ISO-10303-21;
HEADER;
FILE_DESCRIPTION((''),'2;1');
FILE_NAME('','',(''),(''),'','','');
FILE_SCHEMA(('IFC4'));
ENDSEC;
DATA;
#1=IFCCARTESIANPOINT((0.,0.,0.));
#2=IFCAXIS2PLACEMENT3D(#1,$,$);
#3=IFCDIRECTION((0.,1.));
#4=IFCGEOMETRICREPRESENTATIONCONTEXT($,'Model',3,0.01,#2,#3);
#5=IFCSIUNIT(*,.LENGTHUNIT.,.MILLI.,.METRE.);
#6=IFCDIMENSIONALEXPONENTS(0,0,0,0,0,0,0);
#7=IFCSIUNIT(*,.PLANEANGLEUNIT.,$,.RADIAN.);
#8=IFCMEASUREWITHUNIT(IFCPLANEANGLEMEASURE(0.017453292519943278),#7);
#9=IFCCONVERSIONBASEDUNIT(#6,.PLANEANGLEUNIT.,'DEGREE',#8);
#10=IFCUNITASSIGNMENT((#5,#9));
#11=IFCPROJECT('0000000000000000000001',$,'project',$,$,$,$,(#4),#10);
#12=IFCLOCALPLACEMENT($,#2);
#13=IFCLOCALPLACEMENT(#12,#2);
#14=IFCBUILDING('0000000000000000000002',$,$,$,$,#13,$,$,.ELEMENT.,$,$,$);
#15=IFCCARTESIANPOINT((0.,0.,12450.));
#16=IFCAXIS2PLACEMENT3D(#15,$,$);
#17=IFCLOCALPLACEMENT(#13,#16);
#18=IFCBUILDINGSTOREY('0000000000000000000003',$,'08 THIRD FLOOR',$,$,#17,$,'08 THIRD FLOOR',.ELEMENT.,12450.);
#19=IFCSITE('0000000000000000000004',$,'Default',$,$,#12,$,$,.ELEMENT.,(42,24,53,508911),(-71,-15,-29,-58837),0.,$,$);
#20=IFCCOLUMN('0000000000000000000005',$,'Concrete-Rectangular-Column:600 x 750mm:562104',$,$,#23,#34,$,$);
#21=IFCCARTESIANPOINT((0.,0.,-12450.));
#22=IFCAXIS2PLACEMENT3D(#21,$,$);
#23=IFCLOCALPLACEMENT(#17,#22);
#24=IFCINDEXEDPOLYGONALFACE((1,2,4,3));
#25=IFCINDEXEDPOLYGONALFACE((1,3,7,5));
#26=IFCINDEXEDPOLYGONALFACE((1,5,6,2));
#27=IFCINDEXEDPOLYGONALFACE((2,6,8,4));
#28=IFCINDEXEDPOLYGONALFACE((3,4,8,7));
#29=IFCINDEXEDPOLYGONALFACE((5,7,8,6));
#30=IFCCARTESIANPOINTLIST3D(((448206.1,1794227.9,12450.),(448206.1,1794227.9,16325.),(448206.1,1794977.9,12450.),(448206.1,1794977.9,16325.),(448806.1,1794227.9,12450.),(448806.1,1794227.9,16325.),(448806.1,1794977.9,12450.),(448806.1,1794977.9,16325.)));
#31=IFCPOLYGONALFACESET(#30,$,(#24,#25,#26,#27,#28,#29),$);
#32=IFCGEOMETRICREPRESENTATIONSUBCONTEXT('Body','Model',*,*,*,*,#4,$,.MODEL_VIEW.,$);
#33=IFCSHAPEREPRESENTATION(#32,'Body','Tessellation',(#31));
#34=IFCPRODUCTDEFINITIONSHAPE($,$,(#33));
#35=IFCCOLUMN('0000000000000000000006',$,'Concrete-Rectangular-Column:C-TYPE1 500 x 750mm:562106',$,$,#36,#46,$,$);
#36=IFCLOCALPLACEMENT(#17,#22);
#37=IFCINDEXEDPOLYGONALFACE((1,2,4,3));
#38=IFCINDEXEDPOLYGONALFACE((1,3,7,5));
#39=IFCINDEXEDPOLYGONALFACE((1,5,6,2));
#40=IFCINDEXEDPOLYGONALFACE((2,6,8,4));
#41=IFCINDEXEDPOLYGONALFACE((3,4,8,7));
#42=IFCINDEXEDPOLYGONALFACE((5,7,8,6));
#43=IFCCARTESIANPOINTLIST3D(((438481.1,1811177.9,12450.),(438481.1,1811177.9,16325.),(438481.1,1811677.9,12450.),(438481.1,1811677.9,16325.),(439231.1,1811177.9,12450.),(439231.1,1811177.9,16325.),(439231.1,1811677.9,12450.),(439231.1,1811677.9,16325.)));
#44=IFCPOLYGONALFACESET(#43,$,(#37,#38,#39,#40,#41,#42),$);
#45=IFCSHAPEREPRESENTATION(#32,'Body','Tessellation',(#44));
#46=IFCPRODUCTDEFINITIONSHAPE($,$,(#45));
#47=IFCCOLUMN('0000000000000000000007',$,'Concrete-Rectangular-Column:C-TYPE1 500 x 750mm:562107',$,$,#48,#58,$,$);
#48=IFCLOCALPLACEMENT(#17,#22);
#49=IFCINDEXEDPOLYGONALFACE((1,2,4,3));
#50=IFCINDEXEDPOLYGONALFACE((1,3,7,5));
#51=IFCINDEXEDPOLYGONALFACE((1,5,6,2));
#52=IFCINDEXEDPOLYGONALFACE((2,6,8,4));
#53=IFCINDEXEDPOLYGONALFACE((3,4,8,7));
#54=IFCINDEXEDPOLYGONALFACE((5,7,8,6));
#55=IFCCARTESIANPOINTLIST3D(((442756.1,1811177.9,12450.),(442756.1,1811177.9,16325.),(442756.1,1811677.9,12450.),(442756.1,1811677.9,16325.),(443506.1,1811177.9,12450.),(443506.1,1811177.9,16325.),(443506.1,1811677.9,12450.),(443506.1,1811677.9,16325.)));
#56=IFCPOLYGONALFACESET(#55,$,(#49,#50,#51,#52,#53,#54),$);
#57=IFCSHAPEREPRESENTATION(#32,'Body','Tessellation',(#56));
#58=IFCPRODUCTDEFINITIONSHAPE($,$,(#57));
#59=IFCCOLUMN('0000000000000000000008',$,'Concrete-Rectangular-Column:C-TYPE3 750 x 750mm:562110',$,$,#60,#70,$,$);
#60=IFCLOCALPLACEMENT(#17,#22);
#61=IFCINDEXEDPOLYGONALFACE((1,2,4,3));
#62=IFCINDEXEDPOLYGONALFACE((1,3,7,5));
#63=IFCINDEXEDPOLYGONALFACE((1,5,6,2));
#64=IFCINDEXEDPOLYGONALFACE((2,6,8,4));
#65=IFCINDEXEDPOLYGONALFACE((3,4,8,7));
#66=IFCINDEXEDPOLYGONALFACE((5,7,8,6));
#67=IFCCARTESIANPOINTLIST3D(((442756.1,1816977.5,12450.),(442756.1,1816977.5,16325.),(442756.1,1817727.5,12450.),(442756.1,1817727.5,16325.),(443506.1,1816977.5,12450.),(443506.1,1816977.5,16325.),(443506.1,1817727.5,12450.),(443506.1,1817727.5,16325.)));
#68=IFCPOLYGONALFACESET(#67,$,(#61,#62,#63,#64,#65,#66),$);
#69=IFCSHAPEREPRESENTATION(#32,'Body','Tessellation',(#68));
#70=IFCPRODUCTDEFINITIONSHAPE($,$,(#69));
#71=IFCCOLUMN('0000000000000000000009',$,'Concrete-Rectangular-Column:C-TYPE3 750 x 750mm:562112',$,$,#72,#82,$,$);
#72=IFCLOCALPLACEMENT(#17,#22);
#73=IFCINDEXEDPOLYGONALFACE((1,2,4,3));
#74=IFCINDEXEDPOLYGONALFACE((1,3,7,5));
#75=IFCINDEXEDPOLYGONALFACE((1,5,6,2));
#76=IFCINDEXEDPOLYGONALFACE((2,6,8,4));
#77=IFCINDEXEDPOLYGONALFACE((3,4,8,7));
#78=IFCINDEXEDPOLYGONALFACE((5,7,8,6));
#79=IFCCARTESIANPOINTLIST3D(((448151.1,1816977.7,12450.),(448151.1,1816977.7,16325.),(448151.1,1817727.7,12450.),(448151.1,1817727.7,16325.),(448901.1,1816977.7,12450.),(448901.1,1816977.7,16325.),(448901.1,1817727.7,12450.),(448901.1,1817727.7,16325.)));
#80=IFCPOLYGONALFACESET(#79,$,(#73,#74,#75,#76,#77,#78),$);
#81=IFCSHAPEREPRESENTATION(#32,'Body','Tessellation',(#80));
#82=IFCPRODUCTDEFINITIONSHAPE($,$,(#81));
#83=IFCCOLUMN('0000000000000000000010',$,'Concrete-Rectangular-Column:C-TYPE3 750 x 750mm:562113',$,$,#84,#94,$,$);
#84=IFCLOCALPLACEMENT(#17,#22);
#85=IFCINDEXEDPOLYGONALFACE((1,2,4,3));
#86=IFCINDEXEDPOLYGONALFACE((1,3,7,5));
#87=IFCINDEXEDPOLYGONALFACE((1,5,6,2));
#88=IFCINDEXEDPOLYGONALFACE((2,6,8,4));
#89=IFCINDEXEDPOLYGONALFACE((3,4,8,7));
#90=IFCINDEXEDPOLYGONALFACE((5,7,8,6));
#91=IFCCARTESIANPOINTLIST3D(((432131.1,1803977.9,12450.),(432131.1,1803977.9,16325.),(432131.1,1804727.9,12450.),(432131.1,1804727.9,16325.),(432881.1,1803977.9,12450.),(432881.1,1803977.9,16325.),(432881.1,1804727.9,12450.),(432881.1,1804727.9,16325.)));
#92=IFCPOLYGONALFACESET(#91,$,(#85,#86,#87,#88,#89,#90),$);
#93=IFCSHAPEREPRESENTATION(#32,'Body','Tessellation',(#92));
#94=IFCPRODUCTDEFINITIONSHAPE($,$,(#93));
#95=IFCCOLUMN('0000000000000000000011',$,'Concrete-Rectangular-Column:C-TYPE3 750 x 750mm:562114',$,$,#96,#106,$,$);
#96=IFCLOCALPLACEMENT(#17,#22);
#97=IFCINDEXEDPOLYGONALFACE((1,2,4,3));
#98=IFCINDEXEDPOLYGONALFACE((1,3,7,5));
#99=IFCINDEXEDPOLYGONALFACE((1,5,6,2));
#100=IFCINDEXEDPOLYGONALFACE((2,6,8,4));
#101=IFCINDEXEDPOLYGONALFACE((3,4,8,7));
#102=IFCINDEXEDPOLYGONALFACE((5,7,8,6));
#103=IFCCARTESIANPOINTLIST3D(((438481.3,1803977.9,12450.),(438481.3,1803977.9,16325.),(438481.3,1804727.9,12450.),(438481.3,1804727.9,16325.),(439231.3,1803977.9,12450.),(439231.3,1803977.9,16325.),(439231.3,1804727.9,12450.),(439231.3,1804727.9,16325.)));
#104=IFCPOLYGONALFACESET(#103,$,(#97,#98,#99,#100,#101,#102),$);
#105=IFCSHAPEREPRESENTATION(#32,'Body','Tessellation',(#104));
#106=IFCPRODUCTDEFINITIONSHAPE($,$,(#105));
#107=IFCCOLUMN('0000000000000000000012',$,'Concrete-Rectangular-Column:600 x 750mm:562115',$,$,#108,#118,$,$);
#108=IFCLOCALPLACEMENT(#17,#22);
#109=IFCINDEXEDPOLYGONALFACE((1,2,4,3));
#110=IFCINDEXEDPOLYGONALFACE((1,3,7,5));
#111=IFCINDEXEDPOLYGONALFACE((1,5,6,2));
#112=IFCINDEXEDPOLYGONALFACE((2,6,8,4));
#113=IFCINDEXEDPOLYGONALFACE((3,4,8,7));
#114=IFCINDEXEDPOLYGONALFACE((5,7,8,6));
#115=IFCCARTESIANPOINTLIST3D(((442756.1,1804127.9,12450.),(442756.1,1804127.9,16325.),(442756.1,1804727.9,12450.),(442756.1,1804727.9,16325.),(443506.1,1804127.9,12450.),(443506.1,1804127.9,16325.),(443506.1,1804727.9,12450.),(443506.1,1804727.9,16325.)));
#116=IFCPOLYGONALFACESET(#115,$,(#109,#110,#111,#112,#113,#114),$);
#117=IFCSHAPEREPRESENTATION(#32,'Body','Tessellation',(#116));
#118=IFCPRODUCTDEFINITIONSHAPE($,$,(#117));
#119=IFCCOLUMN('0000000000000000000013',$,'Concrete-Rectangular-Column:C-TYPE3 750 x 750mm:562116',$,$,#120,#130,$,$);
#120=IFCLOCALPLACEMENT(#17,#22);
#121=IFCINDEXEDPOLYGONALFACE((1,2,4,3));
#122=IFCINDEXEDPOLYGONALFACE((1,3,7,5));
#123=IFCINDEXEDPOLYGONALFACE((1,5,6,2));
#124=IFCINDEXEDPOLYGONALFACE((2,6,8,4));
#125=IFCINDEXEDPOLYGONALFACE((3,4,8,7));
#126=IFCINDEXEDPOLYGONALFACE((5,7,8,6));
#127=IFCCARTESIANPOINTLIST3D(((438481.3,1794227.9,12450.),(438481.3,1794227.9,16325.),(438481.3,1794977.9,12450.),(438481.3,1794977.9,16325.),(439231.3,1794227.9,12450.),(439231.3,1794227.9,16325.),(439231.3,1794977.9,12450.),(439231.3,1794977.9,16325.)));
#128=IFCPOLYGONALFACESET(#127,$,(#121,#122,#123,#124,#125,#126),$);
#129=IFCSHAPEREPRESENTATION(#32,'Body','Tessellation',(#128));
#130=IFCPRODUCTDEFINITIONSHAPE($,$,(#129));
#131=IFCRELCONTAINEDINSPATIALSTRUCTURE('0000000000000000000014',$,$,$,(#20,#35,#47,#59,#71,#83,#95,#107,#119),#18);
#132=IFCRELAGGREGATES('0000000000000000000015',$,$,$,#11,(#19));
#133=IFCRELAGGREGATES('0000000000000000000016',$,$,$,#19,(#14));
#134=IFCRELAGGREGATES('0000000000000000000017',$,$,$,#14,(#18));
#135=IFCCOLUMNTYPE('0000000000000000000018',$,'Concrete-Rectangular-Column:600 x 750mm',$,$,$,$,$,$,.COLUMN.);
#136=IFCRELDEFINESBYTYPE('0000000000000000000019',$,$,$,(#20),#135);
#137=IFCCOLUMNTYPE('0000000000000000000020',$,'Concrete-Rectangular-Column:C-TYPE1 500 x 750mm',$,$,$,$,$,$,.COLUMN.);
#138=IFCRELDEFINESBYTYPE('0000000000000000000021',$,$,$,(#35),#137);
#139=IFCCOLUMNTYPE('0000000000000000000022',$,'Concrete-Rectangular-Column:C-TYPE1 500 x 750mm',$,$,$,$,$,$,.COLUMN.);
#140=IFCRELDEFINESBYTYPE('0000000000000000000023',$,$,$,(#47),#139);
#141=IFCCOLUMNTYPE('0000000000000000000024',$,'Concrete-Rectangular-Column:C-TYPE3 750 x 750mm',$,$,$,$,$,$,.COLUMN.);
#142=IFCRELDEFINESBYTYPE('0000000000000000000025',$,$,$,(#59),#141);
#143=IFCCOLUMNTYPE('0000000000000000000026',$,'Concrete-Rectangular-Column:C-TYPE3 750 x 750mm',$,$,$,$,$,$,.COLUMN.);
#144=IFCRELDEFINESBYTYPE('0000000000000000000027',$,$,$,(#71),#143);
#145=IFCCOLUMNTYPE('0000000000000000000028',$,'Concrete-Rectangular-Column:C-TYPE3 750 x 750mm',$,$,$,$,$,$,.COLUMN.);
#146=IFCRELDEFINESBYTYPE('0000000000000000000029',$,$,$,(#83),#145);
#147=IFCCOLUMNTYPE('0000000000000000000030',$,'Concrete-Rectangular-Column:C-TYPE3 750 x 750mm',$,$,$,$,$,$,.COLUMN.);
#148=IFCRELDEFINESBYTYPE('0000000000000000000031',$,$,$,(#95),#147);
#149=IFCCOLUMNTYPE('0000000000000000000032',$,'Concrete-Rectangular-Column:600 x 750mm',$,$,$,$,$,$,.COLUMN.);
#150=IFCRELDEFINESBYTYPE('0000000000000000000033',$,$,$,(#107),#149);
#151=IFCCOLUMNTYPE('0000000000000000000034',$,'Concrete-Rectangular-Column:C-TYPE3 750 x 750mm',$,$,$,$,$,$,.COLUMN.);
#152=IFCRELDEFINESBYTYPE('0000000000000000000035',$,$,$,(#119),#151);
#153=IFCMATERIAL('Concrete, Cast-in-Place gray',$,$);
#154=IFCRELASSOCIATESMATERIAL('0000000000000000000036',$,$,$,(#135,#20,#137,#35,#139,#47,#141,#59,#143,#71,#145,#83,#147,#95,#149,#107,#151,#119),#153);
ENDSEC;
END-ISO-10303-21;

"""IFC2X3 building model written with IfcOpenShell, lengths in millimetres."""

from ifc_helpers import new_model, entity, si_unit, converted_unit, direction, frame, frame_2d, origin, place, context, subcontext, project, spatial, rectangle, extrude, source, transform, mapped, material, type_object, type_shapes, element, save


model = new_model("IFC2X3")

# Units and contexts
model_context = context("Model", 3, precision=0.01, world=origin(), true_north=direction((0.0, 1.0)))
body_context = subcontext(model_context, "Body", "Model", "MODEL_VIEW")
ifc_project = project(units=[si_unit("LENGTHUNIT", "METRE", prefix="MILLI"), converted_unit("PLANEANGLEUNIT", "DEGREE", entity("IfcPlaneAngleMeasure", 0.017453292519943278), si_unit("PLANEANGLEUNIT", "RADIAN"), dimensions=[0, 0, 0, 0, 0, 0, 0])], contexts=[model_context])

# Site, building, storey
site_placement = place(None, origin())
site = spatial("IfcSite", under=ifc_project, at=site_placement, Name="Default", CompositionType="ELEMENT", RefLatitude=(42, 24, 53, 508911), RefLongitude=(-71, -15, -29, -58837), RefElevation=0.0)
building_placement = place(site_placement, origin())
building = spatial("IfcBuilding", under=site, at=building_placement, CompositionType="ELEMENT")
storey_placement = place(building_placement, frame((0.0, 0.0, 12450.0)))
storey = spatial("IfcBuildingStorey", under=building, at=storey_placement, Name="08 THIRD FLOOR", LongName="08 THIRD FLOOR", CompositionType="ELEMENT", Elevation=12450.0)

# Columns
ifc_material = material(Name="Concrete, Cast-in-Place gray")
column_type_1 = type_object("IfcColumnType", Name="Concrete-Rectangular-Column:600 x 750mm", PredefinedType="COLUMN", material=ifc_material)
shared_shape_1 = source(origin(), body_context, "Body", "SweptSolid", [
    extrude(rectangle(XDim=3875.0, YDim=750.0, at=frame_2d((0.0, 0.0), x_axis=(1.0, 0.0))), frame((448206.1, 1794602.9, 14387.5), z_axis=(1.0, 0.0, 0.0), x_axis=(0.0, 0.0, 1.0)), (0.0, 0.0, 1.0), 600.0),
])
type_shapes(column_type_1, [shared_shape_1])
column_1_placement = place(storey_placement, frame((0.0, 0.0, -12450.0)))
element("IfcColumn", 1, at=column_1_placement, inside=storey, type_object=column_type_1, material=ifc_material, Name="Concrete-Rectangular-Column:600 x 750mm:562104", context=body_context, shape_type="MappedRepresentation", body=[
    mapped(shared_shape_1, transform((0.0, 0.0, 0.0), scale=1.0)),
])
column_type_2 = type_object("IfcColumnType", Name="Concrete-Rectangular-Column:C-TYPE1 500 x 750mm", PredefinedType="COLUMN", material=ifc_material)
shared_shape_2 = source(origin(), body_context, "Body", "SweptSolid", [
    extrude(rectangle(XDim=500.0, YDim=750.0, at=frame_2d((0.0, 0.0), x_axis=(1.0, 0.0))), frame((438856.1, 1811427.9, 12450.0), z_axis=(0.0, 0.0, 1.0), x_axis=(0.0, -1.0, 0.0)), (0.0, 0.0, 1.0), 3875.0),
])
type_shapes(column_type_2, [shared_shape_2])
column_2_placement = place(storey_placement, frame((0.0, 0.0, -12450.0)))
element("IfcColumn", 2, at=column_2_placement, inside=storey, type_object=column_type_2, material=ifc_material, Name="Concrete-Rectangular-Column:C-TYPE1 500 x 750mm:562106", context=body_context, shape_type="MappedRepresentation", body=[
    mapped(shared_shape_2, transform((0.0, 0.0, 0.0), scale=1.0)),
])
column_type_3 = type_object("IfcColumnType", Name="Concrete-Rectangular-Column:C-TYPE1 500 x 750mm", PredefinedType="COLUMN", material=ifc_material)
shared_shape_3 = source(origin(), body_context, "Body", "SweptSolid", [
    extrude(rectangle(XDim=500.0, YDim=750.0, at=frame_2d((0.0, 0.0), x_axis=(1.0, 0.0))), frame((443131.1, 1811427.9, 12450.0), z_axis=(0.0, 0.0, 1.0), x_axis=(0.0, -1.0, 0.0)), (0.0, 0.0, 1.0), 3875.0),
])
type_shapes(column_type_3, [shared_shape_3])
column_3_placement = place(storey_placement, frame((0.0, 0.0, -12450.0)))
element("IfcColumn", 3, at=column_3_placement, inside=storey, type_object=column_type_3, material=ifc_material, Name="Concrete-Rectangular-Column:C-TYPE1 500 x 750mm:562107", context=body_context, shape_type="MappedRepresentation", body=[
    mapped(shared_shape_3, transform((0.0, 0.0, 0.0), scale=1.0)),
])
column_type_4 = type_object("IfcColumnType", Name="Concrete-Rectangular-Column:C-TYPE3 750 x 750mm", PredefinedType="COLUMN", material=ifc_material)
shared_shape_4 = source(origin(), body_context, "Body", "SweptSolid", [
    extrude(rectangle(XDim=750.0, YDim=750.0, at=frame_2d((0.0, 0.0), x_axis=(1.0, 0.0))), frame((443131.1, 1817352.5, 12450.0), z_axis=(0.0, 0.0, 1.0), x_axis=(0.0, -1.0, 0.0)), (0.0, 0.0, 1.0), 3875.0),
])
type_shapes(column_type_4, [shared_shape_4])
column_4_placement = place(storey_placement, frame((0.0, 0.0, -12450.0)))
element("IfcColumn", 4, at=column_4_placement, inside=storey, type_object=column_type_4, material=ifc_material, Name="Concrete-Rectangular-Column:C-TYPE3 750 x 750mm:562110", context=body_context, shape_type="MappedRepresentation", body=[
    mapped(shared_shape_4, transform((0.0, 0.0, 0.0), scale=1.0)),
])
column_type_5 = type_object("IfcColumnType", Name="Concrete-Rectangular-Column:C-TYPE3 750 x 750mm", PredefinedType="COLUMN", material=ifc_material)
shared_shape_5 = source(origin(), body_context, "Body", "SweptSolid", [
    extrude(rectangle(XDim=750.0, YDim=750.0, at=frame_2d((0.0, 0.0), x_axis=(1.0, 0.0))), frame((448526.1, 1817352.7, 12450.0), z_axis=(0.0, 0.0, 1.0), x_axis=(0.0, -1.0, 0.0)), (0.0, 0.0, 1.0), 3875.0),
])
type_shapes(column_type_5, [shared_shape_5])
column_5_placement = place(storey_placement, frame((0.0, 0.0, -12450.0)))
element("IfcColumn", 5, at=column_5_placement, inside=storey, type_object=column_type_5, material=ifc_material, Name="Concrete-Rectangular-Column:C-TYPE3 750 x 750mm:562112", context=body_context, shape_type="MappedRepresentation", body=[
    mapped(shared_shape_5, transform((0.0, 0.0, 0.0), scale=1.0)),
])
column_type_6 = type_object("IfcColumnType", Name="Concrete-Rectangular-Column:C-TYPE3 750 x 750mm", PredefinedType="COLUMN", material=ifc_material)
shared_shape_6 = source(origin(), body_context, "Body", "SweptSolid", [
    extrude(rectangle(XDim=750.0, YDim=750.0, at=frame_2d((0.0, 0.0), x_axis=(1.0, 0.0))), frame((432506.1, 1804352.9, 12450.0), z_axis=(0.0, 0.0, 1.0), x_axis=(0.0, -1.0, 0.0)), (0.0, 0.0, 1.0), 3875.0),
])
type_shapes(column_type_6, [shared_shape_6])
column_6_placement = place(storey_placement, frame((0.0, 0.0, -12450.0)))
element("IfcColumn", 6, at=column_6_placement, inside=storey, type_object=column_type_6, material=ifc_material, Name="Concrete-Rectangular-Column:C-TYPE3 750 x 750mm:562113", context=body_context, shape_type="MappedRepresentation", body=[
    mapped(shared_shape_6, transform((0.0, 0.0, 0.0), scale=1.0)),
])
column_type_7 = type_object("IfcColumnType", Name="Concrete-Rectangular-Column:C-TYPE3 750 x 750mm", PredefinedType="COLUMN", material=ifc_material)
shared_shape_7 = source(origin(), body_context, "Body", "SweptSolid", [
    extrude(rectangle(XDim=750.0, YDim=750.0, at=frame_2d((0.0, 0.0), x_axis=(1.0, 0.0))), frame((438856.3, 1804352.9, 12450.0), z_axis=(0.0, 0.0, 1.0), x_axis=(0.0, -1.0, 0.0)), (0.0, 0.0, 1.0), 3875.0),
])
type_shapes(column_type_7, [shared_shape_7])
column_7_placement = place(storey_placement, frame((0.0, 0.0, -12450.0)))
element("IfcColumn", 7, at=column_7_placement, inside=storey, type_object=column_type_7, material=ifc_material, Name="Concrete-Rectangular-Column:C-TYPE3 750 x 750mm:562114", context=body_context, shape_type="MappedRepresentation", body=[
    mapped(shared_shape_7, transform((0.0, 0.0, 0.0), scale=1.0)),
])
column_type_8 = type_object("IfcColumnType", Name="Concrete-Rectangular-Column:600 x 750mm", PredefinedType="COLUMN", material=ifc_material)
shared_shape_8 = source(origin(), body_context, "Body", "SweptSolid", [
    extrude(rectangle(XDim=600.0, YDim=750.0, at=frame_2d((0.0, 0.0), x_axis=(1.0, 0.0))), frame((443131.1, 1804427.9, 12450.0), z_axis=(0.0, 0.0, 1.0), x_axis=(0.0, -1.0, 0.0)), (0.0, 0.0, 1.0), 3875.0),
])
type_shapes(column_type_8, [shared_shape_8])
column_8_placement = place(storey_placement, frame((0.0, 0.0, -12450.0)))
element("IfcColumn", 8, at=column_8_placement, inside=storey, type_object=column_type_8, material=ifc_material, Name="Concrete-Rectangular-Column:600 x 750mm:562115", context=body_context, shape_type="MappedRepresentation", body=[
    mapped(shared_shape_8, transform((0.0, 0.0, 0.0), scale=1.0)),
])
column_type_9 = type_object("IfcColumnType", Name="Concrete-Rectangular-Column:C-TYPE3 750 x 750mm", PredefinedType="COLUMN", material=ifc_material)
shared_shape_9 = source(origin(), body_context, "Body", "SweptSolid", [
    extrude(rectangle(XDim=750.0, YDim=750.0, at=frame_2d((0.0, 0.0), x_axis=(1.0, 0.0))), frame((438856.3, 1794602.9, 12450.0), z_axis=(0.0, 0.0, 1.0), x_axis=(0.0, -1.0, 0.0)), (0.0, 0.0, 1.0), 3875.0),
])
type_shapes(column_type_9, [shared_shape_9])
column_9_placement = place(storey_placement, frame((0.0, 0.0, -12450.0)))
element("IfcColumn", 9, at=column_9_placement, inside=storey, type_object=column_type_9, material=ifc_material, Name="Concrete-Rectangular-Column:C-TYPE3 750 x 750mm:562116", context=body_context, shape_type="MappedRepresentation", body=[
    mapped(shared_shape_9, transform((0.0, 0.0, 0.0), scale=1.0)),
])

save(model, "model.ifc")
